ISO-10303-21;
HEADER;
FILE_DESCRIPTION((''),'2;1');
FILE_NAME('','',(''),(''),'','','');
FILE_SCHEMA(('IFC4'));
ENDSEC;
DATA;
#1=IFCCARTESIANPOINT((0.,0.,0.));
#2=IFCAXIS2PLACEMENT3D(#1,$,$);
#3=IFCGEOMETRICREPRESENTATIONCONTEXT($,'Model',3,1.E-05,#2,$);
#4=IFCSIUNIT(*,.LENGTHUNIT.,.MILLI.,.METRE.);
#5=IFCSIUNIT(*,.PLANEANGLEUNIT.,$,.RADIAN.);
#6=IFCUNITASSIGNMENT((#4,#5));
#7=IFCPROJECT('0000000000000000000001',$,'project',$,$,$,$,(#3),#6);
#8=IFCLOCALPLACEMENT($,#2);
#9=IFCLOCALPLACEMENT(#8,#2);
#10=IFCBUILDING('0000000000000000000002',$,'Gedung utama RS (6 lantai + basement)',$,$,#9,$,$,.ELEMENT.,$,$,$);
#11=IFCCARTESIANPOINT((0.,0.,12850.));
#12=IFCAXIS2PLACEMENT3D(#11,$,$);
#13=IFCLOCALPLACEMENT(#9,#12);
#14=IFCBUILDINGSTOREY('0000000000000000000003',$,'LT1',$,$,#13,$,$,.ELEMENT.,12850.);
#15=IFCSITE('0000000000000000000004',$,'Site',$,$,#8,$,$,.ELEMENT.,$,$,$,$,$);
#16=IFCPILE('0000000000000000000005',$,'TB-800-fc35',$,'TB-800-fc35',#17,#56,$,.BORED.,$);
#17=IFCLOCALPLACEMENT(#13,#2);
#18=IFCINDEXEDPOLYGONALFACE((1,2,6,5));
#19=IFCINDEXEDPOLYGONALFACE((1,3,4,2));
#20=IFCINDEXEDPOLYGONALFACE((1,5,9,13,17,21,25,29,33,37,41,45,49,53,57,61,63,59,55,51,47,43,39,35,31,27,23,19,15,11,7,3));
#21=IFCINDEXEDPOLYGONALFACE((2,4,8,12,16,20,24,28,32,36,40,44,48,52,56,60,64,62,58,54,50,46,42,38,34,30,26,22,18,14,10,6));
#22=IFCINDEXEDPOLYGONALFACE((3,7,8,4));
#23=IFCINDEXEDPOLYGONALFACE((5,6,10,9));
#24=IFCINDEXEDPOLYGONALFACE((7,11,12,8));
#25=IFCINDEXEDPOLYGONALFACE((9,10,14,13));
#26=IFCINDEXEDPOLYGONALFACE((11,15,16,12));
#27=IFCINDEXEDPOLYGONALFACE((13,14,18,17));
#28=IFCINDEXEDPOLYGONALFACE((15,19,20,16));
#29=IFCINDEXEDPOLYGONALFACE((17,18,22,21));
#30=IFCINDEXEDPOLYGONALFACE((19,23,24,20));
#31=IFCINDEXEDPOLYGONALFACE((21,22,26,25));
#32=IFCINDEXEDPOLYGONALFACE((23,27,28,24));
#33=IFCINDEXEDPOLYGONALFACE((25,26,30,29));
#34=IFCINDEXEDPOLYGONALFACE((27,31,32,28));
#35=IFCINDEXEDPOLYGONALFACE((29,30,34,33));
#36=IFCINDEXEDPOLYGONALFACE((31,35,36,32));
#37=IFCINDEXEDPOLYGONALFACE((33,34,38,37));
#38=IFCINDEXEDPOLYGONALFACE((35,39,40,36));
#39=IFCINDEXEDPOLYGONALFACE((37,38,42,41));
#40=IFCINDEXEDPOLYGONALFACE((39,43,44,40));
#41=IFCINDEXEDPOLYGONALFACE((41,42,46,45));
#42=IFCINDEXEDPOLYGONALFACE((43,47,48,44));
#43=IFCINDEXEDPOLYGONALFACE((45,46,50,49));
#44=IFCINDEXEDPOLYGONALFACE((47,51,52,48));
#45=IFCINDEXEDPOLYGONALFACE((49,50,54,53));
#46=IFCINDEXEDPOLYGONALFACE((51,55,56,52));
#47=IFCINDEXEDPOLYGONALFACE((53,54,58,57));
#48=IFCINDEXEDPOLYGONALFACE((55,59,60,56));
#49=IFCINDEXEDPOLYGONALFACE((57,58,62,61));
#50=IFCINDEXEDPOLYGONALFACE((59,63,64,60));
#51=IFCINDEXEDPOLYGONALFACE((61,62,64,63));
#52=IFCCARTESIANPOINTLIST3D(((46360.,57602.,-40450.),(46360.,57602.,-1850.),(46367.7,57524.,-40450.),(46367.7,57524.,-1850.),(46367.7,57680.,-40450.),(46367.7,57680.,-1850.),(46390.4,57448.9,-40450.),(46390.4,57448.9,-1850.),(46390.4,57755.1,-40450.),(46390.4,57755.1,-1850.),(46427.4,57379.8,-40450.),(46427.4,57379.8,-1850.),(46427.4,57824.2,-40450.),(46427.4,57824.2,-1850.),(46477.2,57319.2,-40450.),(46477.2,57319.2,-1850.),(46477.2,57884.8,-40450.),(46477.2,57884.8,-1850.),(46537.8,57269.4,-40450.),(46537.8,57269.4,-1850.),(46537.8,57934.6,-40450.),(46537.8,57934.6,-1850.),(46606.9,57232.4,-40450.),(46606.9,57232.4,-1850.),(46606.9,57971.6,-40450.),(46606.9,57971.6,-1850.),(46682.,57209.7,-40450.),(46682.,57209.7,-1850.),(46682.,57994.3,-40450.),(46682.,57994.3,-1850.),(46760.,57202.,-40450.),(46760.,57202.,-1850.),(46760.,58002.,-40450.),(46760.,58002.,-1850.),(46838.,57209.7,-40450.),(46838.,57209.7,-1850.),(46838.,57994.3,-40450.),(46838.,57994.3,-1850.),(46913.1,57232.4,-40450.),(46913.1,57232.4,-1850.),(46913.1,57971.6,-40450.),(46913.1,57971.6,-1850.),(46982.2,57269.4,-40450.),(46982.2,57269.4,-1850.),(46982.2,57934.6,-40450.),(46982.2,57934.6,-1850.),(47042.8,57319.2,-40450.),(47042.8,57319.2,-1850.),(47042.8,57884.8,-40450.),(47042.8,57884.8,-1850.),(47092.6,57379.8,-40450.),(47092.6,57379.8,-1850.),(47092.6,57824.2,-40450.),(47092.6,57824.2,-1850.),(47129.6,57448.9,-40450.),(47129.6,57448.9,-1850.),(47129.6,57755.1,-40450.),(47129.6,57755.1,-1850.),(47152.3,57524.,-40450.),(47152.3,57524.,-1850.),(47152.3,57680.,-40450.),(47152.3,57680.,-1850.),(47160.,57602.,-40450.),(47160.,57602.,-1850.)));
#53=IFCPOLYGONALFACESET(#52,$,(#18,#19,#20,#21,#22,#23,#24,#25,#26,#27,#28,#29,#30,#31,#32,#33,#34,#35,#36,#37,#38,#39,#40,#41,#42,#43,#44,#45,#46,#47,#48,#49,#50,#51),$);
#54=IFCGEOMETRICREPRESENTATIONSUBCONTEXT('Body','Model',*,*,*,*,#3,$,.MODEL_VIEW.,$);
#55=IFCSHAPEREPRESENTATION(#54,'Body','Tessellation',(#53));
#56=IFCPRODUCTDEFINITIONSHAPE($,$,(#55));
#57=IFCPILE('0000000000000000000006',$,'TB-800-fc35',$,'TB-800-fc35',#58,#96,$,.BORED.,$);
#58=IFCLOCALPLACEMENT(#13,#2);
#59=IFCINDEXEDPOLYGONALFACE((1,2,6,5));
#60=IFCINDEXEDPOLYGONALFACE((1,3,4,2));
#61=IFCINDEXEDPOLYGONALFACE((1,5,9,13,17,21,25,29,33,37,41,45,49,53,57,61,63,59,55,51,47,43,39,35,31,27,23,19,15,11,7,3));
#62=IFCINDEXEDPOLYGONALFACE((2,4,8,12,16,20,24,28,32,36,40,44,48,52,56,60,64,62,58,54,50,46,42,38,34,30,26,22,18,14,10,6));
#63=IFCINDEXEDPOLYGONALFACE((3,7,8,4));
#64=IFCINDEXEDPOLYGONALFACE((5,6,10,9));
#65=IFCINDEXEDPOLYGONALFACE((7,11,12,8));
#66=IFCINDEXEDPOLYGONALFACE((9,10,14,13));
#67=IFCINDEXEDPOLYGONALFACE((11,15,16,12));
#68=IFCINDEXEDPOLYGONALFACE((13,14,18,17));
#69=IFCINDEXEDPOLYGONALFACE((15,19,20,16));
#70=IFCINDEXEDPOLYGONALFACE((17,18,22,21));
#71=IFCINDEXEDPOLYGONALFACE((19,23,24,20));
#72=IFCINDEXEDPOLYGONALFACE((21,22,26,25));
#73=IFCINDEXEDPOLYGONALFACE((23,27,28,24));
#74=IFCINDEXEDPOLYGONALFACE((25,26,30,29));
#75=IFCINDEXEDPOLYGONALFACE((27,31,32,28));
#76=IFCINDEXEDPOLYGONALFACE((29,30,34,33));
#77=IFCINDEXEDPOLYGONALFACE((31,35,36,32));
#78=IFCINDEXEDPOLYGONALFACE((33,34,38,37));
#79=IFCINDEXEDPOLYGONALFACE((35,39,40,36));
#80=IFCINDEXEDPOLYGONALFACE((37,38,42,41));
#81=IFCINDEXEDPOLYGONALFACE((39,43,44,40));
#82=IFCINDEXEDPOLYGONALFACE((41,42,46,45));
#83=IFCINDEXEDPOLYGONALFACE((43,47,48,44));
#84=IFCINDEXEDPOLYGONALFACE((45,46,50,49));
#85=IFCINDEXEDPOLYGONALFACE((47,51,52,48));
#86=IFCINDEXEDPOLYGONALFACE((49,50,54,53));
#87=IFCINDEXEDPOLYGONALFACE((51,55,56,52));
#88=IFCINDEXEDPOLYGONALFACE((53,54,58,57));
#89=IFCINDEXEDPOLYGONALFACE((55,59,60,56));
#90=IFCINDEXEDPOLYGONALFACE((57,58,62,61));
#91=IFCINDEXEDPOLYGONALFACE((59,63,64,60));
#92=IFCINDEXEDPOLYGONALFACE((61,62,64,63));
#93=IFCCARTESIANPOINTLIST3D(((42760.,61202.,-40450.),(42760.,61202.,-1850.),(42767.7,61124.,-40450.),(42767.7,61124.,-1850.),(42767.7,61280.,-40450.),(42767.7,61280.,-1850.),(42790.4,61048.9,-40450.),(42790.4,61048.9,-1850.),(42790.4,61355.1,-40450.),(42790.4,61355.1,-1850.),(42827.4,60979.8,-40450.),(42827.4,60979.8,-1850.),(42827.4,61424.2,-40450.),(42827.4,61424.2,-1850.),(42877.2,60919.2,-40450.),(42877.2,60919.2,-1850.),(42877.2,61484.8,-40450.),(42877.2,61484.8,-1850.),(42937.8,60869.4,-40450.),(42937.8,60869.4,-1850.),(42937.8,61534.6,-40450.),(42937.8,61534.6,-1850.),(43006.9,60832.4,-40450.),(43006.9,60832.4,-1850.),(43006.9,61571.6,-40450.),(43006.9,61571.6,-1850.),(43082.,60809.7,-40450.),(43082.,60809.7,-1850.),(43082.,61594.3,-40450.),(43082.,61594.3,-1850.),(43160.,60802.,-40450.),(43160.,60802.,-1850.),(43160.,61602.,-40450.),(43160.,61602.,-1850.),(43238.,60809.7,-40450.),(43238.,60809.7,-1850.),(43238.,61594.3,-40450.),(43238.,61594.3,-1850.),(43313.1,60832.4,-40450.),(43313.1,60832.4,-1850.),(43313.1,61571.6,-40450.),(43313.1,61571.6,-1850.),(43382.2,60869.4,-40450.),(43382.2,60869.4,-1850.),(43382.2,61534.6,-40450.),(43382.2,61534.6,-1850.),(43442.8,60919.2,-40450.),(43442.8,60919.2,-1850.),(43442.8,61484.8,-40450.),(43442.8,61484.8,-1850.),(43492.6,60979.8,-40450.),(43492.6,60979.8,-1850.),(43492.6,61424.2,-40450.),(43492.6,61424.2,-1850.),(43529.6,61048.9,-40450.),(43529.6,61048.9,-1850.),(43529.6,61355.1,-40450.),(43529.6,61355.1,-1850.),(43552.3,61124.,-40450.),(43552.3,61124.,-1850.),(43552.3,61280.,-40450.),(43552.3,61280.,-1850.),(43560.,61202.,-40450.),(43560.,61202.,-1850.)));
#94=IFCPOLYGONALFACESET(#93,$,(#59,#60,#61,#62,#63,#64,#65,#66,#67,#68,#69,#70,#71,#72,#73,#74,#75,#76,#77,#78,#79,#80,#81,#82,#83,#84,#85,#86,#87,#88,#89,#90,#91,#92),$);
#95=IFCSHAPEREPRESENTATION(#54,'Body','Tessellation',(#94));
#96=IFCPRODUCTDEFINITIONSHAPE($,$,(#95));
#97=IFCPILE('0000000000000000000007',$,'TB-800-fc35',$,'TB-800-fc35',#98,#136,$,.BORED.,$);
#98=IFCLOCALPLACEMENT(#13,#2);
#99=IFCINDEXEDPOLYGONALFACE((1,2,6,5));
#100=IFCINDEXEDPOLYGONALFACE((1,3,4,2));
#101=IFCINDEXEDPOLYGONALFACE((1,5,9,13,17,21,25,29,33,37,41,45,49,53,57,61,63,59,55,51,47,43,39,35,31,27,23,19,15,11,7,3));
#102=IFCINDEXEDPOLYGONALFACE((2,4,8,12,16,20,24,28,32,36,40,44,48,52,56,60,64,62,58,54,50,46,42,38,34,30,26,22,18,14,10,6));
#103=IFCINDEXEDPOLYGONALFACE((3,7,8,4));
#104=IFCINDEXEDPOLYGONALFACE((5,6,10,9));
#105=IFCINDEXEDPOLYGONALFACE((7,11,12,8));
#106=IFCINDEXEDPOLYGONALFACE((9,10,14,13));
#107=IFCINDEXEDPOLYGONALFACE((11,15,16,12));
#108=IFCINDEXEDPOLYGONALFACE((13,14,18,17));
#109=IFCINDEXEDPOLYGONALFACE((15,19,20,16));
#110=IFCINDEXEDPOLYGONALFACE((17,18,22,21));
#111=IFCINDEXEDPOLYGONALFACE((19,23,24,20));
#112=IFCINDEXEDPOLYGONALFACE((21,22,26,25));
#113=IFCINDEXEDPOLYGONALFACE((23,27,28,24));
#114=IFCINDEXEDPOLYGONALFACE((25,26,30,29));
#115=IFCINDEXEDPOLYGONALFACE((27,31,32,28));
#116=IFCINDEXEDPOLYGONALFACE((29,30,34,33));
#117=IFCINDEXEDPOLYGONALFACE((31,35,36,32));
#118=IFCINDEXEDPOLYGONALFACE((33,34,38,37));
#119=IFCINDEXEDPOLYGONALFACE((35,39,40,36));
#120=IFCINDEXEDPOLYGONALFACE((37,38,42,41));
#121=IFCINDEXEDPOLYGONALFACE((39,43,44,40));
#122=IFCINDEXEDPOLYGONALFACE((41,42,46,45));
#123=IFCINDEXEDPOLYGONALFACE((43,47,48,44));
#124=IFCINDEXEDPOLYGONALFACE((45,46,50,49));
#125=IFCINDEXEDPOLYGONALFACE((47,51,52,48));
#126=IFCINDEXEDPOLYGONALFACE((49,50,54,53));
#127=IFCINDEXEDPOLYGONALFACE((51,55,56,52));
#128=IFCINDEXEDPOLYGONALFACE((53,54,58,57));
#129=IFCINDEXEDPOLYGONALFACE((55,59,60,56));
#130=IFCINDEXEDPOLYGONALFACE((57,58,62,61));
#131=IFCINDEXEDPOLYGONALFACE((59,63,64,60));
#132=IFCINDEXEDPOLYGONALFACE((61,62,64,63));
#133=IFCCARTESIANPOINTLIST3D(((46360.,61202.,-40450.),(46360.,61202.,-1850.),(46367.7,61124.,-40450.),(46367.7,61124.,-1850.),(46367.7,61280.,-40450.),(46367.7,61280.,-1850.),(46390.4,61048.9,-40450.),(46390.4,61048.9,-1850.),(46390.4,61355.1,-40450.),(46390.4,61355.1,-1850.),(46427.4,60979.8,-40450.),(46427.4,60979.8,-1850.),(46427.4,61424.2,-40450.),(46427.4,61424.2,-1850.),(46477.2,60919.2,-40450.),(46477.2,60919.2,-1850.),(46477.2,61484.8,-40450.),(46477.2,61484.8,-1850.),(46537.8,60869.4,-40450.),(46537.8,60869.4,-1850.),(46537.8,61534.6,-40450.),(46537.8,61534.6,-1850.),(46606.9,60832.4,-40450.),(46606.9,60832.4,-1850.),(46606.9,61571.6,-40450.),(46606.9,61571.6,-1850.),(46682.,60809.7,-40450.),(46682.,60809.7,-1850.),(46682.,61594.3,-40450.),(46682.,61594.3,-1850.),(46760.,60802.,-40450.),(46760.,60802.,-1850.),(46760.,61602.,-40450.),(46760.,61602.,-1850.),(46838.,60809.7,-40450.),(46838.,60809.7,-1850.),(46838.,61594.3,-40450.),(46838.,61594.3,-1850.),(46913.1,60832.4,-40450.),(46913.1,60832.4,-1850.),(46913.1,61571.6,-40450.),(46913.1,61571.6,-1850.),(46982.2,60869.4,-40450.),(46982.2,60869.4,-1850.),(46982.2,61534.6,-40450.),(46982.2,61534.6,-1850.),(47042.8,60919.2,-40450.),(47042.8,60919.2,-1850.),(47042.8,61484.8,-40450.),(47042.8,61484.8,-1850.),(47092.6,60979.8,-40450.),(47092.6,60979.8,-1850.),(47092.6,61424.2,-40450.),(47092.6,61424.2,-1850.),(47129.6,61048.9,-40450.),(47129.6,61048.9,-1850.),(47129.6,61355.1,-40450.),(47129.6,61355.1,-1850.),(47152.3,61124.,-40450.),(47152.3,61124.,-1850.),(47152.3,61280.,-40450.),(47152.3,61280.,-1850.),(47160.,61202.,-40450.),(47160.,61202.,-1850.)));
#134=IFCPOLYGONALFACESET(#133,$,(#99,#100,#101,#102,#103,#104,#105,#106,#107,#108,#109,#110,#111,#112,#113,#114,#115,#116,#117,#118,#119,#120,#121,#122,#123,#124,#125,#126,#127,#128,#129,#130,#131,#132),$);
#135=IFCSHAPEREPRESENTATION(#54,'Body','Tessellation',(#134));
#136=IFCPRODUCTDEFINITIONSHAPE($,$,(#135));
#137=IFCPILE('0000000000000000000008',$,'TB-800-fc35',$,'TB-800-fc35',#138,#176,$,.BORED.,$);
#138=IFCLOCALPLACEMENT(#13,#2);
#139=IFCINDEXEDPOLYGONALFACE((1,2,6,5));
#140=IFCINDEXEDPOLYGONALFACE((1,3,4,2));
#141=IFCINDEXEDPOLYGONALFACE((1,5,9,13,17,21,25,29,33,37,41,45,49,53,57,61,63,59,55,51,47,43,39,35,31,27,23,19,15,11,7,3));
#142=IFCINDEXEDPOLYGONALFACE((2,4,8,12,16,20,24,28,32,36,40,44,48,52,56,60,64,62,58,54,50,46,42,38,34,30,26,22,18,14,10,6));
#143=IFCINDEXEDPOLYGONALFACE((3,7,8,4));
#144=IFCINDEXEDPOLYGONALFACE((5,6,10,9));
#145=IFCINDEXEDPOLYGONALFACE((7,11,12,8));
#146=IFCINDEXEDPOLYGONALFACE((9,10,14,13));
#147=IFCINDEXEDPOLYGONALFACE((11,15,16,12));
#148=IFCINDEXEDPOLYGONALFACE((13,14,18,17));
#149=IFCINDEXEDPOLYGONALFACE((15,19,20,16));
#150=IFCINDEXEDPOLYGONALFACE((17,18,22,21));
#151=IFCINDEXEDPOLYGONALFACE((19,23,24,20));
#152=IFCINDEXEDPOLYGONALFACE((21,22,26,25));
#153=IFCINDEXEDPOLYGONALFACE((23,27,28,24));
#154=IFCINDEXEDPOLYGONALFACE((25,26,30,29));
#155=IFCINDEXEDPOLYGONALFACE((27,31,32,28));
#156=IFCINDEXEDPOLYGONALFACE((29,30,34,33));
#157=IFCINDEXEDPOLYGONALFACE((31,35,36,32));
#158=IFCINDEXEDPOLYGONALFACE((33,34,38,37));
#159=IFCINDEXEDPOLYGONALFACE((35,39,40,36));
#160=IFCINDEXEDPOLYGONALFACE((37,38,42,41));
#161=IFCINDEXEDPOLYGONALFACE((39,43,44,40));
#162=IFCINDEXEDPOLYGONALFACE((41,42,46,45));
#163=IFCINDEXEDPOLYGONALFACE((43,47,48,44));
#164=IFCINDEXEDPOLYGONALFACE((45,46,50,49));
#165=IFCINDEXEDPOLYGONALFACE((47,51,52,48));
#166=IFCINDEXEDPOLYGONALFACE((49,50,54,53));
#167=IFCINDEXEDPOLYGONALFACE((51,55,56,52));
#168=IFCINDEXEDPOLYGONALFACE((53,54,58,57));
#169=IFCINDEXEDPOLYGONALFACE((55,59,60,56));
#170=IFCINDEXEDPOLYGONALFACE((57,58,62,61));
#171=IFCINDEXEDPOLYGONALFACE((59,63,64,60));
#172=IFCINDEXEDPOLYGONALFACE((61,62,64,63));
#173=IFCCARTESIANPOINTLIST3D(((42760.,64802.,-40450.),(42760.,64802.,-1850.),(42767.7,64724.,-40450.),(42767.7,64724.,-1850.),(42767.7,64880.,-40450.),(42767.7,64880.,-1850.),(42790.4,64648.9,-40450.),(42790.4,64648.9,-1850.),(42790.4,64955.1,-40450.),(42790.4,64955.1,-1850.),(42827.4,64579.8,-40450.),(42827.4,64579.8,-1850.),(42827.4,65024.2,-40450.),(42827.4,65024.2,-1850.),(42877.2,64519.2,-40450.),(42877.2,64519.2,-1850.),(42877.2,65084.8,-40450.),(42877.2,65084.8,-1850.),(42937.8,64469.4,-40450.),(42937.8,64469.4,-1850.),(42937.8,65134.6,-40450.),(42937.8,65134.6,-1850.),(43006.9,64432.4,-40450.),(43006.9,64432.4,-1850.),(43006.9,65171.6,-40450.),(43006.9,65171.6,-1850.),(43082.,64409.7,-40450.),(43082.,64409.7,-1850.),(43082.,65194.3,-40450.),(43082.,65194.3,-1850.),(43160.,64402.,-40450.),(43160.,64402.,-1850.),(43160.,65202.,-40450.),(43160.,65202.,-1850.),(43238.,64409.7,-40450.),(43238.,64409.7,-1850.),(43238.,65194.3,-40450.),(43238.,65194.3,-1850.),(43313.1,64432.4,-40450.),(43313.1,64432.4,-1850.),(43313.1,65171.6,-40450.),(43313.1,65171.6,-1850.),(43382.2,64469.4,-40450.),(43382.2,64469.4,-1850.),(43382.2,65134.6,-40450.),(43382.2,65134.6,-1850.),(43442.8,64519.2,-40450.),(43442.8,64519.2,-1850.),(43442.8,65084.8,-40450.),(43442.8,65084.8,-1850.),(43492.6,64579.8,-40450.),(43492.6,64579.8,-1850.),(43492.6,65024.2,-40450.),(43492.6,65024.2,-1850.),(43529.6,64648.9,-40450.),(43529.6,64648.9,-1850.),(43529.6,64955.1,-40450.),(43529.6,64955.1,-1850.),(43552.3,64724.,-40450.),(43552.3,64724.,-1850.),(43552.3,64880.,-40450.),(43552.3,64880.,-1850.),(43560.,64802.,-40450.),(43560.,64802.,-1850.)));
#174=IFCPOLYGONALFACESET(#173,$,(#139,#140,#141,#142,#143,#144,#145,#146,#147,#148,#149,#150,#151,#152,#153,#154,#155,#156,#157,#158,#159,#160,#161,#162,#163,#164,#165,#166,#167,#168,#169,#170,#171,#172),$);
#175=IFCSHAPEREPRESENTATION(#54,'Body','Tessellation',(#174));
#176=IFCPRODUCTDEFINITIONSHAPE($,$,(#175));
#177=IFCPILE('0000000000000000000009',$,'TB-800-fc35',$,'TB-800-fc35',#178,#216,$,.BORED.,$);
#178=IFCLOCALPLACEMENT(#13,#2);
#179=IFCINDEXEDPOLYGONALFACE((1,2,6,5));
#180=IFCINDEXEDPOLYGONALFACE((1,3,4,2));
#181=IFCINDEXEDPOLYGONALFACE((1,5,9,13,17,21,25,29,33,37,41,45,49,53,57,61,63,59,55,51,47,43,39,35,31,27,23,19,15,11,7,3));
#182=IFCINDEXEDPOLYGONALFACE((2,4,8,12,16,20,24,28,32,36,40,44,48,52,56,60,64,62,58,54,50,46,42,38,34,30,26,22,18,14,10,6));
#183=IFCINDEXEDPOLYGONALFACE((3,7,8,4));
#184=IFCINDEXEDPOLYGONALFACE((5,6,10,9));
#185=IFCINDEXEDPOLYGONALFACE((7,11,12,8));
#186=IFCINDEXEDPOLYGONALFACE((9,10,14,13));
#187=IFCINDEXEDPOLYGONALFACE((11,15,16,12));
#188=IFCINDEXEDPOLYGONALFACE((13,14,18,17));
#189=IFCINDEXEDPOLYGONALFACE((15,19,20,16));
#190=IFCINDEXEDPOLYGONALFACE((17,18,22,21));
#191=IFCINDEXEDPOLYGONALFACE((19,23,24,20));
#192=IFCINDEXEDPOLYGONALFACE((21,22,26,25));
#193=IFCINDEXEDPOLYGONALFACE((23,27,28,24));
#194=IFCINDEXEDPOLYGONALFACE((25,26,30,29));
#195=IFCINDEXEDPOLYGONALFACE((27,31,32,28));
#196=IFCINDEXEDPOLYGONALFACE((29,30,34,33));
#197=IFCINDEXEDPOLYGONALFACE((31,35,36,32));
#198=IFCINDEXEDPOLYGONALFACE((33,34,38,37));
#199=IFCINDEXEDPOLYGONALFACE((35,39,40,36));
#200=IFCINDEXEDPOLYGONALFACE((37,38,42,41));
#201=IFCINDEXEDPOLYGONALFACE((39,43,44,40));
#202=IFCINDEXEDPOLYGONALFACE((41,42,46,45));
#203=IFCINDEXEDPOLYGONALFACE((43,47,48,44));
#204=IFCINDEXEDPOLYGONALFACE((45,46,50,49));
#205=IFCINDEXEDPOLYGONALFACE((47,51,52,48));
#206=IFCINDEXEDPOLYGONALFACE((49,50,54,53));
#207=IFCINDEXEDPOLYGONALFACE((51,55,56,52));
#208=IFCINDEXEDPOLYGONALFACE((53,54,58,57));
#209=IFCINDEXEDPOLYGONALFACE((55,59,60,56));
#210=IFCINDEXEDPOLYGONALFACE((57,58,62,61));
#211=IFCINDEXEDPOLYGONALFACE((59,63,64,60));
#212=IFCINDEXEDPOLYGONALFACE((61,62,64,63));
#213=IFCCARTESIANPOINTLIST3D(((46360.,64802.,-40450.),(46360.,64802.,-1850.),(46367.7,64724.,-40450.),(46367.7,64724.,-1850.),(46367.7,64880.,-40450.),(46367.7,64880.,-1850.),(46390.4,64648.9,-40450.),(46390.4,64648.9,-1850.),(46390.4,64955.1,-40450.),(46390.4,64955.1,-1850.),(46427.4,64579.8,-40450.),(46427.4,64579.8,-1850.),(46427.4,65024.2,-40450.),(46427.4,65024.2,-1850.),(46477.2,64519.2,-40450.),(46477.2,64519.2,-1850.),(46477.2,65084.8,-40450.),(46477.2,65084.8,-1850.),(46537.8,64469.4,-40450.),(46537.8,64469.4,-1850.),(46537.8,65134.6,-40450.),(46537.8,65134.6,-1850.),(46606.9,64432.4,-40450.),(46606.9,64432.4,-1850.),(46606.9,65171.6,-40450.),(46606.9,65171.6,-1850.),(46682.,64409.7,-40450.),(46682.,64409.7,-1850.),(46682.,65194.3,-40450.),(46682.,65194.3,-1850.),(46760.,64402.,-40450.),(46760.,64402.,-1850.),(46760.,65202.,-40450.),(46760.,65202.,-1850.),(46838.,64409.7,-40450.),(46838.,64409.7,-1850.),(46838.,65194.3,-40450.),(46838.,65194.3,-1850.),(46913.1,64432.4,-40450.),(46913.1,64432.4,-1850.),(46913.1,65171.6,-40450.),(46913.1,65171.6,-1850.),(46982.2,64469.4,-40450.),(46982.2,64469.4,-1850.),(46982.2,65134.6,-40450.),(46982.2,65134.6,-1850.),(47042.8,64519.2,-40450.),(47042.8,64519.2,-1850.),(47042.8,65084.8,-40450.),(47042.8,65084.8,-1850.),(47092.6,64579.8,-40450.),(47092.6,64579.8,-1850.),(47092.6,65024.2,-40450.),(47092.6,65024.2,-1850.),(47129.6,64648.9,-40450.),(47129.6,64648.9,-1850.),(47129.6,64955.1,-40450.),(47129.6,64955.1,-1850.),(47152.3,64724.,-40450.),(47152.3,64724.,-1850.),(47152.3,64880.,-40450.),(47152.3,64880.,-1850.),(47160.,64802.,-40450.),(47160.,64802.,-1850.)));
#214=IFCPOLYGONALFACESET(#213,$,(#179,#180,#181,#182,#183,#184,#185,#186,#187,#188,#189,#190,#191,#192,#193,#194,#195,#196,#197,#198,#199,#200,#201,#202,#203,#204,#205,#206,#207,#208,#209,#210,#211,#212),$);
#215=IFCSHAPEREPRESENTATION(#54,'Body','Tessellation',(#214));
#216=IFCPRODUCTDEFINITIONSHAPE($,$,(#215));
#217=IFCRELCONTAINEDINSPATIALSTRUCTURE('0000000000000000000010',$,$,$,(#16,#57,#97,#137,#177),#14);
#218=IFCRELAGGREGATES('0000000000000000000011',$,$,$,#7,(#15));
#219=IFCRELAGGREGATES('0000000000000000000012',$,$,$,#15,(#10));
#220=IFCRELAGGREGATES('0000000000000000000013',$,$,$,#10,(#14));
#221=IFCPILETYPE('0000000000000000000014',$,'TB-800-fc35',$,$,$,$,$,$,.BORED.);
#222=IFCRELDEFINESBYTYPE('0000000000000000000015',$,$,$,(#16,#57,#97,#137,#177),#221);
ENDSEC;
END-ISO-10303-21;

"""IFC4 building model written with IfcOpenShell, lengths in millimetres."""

from ifc_helpers import new_model, si_unit, frame, origin, origin_2d, place, context, subcontext, project, spatial, circle, extrude, material_profile, profile_set, profile_usage, type_object, element, save


model = new_model("IFC4")

# Units and contexts
model_context = context("Model", 3, precision=1e-05, world=origin())
body_context = subcontext(model_context, "Body", "Model", "MODEL_VIEW")
ifc_project = project(units=[si_unit("LENGTHUNIT", "METRE", prefix="MILLI"), si_unit("PLANEANGLEUNIT", "RADIAN")], contexts=[model_context])

# Site, building, storey
site_placement = place(None, origin())
site = spatial("IfcSite", under=ifc_project, at=site_placement, Name="Site", CompositionType="ELEMENT")
building_placement = place(site_placement, origin())
building = spatial("IfcBuilding", under=site, at=building_placement, Name="Gedung utama RS (6 lantai + basement)", CompositionType="ELEMENT")
storey_placement = place(building_placement, frame((0.0, 0.0, 12850.0)))
storey = spatial("IfcBuildingStorey", under=building, at=storey_placement, Name="LT1", CompositionType="ELEMENT", Elevation=12850.0)

# Piles
ifc_material_profile_1 = material_profile(None, circle(Radius=400.0, at=origin_2d()), Name="TB-800-fc35")
ifc_profile_set_1 = profile_set([ifc_material_profile_1], Name="TB-800-fc35")
ifc_profile_usage_1 = profile_usage(ifc_profile_set_1, cardinal=5)
pile_type = type_object("IfcPileType", Name="TB-800-fc35", PredefinedType="BORED", material=ifc_profile_set_1)
for number, where, z_axis, x_axis, name in (
    (1, (46760.0, 57602.0, -40450.0), (0.0, 0.0, 1.0), (1.0, 0.0, 0.0), "TB-800-fc35"),
    (2, (43160.0, 61202.0, -40450.0), (0.0, 0.0, 1.0), (1.0, 0.0, 0.0), "TB-800-fc35"),
    (3, (46760.0, 61202.0, -40450.0), (0.0, 0.0, 1.0), (1.0, 0.0, 0.0), "TB-800-fc35"),
    (4, (43160.0, 64802.0, -40450.0), (0.0, 0.0, 1.0), (1.0, 0.0, 0.0), "TB-800-fc35"),
    (5, (46760.0, 64802.0, -40450.0), (0.0, 0.0, 1.0), (1.0, 0.0, 0.0), "TB-800-fc35"),
):
    element("IfcPile", number, at=place(storey_placement, frame(where, z_axis=z_axis, x_axis=x_axis)), inside=storey, type_object=pile_type, material=ifc_profile_usage_1, Name=name, ObjectType="TB-800-fc35", PredefinedType="BORED", context=body_context, shape_type="SweptSolid", body=[
        extrude(circle(Radius=400.0, at=origin_2d()), origin(), (0.0, 0.0, 1.0), 38600.0),
    ])

save(model, "model.ifc")
